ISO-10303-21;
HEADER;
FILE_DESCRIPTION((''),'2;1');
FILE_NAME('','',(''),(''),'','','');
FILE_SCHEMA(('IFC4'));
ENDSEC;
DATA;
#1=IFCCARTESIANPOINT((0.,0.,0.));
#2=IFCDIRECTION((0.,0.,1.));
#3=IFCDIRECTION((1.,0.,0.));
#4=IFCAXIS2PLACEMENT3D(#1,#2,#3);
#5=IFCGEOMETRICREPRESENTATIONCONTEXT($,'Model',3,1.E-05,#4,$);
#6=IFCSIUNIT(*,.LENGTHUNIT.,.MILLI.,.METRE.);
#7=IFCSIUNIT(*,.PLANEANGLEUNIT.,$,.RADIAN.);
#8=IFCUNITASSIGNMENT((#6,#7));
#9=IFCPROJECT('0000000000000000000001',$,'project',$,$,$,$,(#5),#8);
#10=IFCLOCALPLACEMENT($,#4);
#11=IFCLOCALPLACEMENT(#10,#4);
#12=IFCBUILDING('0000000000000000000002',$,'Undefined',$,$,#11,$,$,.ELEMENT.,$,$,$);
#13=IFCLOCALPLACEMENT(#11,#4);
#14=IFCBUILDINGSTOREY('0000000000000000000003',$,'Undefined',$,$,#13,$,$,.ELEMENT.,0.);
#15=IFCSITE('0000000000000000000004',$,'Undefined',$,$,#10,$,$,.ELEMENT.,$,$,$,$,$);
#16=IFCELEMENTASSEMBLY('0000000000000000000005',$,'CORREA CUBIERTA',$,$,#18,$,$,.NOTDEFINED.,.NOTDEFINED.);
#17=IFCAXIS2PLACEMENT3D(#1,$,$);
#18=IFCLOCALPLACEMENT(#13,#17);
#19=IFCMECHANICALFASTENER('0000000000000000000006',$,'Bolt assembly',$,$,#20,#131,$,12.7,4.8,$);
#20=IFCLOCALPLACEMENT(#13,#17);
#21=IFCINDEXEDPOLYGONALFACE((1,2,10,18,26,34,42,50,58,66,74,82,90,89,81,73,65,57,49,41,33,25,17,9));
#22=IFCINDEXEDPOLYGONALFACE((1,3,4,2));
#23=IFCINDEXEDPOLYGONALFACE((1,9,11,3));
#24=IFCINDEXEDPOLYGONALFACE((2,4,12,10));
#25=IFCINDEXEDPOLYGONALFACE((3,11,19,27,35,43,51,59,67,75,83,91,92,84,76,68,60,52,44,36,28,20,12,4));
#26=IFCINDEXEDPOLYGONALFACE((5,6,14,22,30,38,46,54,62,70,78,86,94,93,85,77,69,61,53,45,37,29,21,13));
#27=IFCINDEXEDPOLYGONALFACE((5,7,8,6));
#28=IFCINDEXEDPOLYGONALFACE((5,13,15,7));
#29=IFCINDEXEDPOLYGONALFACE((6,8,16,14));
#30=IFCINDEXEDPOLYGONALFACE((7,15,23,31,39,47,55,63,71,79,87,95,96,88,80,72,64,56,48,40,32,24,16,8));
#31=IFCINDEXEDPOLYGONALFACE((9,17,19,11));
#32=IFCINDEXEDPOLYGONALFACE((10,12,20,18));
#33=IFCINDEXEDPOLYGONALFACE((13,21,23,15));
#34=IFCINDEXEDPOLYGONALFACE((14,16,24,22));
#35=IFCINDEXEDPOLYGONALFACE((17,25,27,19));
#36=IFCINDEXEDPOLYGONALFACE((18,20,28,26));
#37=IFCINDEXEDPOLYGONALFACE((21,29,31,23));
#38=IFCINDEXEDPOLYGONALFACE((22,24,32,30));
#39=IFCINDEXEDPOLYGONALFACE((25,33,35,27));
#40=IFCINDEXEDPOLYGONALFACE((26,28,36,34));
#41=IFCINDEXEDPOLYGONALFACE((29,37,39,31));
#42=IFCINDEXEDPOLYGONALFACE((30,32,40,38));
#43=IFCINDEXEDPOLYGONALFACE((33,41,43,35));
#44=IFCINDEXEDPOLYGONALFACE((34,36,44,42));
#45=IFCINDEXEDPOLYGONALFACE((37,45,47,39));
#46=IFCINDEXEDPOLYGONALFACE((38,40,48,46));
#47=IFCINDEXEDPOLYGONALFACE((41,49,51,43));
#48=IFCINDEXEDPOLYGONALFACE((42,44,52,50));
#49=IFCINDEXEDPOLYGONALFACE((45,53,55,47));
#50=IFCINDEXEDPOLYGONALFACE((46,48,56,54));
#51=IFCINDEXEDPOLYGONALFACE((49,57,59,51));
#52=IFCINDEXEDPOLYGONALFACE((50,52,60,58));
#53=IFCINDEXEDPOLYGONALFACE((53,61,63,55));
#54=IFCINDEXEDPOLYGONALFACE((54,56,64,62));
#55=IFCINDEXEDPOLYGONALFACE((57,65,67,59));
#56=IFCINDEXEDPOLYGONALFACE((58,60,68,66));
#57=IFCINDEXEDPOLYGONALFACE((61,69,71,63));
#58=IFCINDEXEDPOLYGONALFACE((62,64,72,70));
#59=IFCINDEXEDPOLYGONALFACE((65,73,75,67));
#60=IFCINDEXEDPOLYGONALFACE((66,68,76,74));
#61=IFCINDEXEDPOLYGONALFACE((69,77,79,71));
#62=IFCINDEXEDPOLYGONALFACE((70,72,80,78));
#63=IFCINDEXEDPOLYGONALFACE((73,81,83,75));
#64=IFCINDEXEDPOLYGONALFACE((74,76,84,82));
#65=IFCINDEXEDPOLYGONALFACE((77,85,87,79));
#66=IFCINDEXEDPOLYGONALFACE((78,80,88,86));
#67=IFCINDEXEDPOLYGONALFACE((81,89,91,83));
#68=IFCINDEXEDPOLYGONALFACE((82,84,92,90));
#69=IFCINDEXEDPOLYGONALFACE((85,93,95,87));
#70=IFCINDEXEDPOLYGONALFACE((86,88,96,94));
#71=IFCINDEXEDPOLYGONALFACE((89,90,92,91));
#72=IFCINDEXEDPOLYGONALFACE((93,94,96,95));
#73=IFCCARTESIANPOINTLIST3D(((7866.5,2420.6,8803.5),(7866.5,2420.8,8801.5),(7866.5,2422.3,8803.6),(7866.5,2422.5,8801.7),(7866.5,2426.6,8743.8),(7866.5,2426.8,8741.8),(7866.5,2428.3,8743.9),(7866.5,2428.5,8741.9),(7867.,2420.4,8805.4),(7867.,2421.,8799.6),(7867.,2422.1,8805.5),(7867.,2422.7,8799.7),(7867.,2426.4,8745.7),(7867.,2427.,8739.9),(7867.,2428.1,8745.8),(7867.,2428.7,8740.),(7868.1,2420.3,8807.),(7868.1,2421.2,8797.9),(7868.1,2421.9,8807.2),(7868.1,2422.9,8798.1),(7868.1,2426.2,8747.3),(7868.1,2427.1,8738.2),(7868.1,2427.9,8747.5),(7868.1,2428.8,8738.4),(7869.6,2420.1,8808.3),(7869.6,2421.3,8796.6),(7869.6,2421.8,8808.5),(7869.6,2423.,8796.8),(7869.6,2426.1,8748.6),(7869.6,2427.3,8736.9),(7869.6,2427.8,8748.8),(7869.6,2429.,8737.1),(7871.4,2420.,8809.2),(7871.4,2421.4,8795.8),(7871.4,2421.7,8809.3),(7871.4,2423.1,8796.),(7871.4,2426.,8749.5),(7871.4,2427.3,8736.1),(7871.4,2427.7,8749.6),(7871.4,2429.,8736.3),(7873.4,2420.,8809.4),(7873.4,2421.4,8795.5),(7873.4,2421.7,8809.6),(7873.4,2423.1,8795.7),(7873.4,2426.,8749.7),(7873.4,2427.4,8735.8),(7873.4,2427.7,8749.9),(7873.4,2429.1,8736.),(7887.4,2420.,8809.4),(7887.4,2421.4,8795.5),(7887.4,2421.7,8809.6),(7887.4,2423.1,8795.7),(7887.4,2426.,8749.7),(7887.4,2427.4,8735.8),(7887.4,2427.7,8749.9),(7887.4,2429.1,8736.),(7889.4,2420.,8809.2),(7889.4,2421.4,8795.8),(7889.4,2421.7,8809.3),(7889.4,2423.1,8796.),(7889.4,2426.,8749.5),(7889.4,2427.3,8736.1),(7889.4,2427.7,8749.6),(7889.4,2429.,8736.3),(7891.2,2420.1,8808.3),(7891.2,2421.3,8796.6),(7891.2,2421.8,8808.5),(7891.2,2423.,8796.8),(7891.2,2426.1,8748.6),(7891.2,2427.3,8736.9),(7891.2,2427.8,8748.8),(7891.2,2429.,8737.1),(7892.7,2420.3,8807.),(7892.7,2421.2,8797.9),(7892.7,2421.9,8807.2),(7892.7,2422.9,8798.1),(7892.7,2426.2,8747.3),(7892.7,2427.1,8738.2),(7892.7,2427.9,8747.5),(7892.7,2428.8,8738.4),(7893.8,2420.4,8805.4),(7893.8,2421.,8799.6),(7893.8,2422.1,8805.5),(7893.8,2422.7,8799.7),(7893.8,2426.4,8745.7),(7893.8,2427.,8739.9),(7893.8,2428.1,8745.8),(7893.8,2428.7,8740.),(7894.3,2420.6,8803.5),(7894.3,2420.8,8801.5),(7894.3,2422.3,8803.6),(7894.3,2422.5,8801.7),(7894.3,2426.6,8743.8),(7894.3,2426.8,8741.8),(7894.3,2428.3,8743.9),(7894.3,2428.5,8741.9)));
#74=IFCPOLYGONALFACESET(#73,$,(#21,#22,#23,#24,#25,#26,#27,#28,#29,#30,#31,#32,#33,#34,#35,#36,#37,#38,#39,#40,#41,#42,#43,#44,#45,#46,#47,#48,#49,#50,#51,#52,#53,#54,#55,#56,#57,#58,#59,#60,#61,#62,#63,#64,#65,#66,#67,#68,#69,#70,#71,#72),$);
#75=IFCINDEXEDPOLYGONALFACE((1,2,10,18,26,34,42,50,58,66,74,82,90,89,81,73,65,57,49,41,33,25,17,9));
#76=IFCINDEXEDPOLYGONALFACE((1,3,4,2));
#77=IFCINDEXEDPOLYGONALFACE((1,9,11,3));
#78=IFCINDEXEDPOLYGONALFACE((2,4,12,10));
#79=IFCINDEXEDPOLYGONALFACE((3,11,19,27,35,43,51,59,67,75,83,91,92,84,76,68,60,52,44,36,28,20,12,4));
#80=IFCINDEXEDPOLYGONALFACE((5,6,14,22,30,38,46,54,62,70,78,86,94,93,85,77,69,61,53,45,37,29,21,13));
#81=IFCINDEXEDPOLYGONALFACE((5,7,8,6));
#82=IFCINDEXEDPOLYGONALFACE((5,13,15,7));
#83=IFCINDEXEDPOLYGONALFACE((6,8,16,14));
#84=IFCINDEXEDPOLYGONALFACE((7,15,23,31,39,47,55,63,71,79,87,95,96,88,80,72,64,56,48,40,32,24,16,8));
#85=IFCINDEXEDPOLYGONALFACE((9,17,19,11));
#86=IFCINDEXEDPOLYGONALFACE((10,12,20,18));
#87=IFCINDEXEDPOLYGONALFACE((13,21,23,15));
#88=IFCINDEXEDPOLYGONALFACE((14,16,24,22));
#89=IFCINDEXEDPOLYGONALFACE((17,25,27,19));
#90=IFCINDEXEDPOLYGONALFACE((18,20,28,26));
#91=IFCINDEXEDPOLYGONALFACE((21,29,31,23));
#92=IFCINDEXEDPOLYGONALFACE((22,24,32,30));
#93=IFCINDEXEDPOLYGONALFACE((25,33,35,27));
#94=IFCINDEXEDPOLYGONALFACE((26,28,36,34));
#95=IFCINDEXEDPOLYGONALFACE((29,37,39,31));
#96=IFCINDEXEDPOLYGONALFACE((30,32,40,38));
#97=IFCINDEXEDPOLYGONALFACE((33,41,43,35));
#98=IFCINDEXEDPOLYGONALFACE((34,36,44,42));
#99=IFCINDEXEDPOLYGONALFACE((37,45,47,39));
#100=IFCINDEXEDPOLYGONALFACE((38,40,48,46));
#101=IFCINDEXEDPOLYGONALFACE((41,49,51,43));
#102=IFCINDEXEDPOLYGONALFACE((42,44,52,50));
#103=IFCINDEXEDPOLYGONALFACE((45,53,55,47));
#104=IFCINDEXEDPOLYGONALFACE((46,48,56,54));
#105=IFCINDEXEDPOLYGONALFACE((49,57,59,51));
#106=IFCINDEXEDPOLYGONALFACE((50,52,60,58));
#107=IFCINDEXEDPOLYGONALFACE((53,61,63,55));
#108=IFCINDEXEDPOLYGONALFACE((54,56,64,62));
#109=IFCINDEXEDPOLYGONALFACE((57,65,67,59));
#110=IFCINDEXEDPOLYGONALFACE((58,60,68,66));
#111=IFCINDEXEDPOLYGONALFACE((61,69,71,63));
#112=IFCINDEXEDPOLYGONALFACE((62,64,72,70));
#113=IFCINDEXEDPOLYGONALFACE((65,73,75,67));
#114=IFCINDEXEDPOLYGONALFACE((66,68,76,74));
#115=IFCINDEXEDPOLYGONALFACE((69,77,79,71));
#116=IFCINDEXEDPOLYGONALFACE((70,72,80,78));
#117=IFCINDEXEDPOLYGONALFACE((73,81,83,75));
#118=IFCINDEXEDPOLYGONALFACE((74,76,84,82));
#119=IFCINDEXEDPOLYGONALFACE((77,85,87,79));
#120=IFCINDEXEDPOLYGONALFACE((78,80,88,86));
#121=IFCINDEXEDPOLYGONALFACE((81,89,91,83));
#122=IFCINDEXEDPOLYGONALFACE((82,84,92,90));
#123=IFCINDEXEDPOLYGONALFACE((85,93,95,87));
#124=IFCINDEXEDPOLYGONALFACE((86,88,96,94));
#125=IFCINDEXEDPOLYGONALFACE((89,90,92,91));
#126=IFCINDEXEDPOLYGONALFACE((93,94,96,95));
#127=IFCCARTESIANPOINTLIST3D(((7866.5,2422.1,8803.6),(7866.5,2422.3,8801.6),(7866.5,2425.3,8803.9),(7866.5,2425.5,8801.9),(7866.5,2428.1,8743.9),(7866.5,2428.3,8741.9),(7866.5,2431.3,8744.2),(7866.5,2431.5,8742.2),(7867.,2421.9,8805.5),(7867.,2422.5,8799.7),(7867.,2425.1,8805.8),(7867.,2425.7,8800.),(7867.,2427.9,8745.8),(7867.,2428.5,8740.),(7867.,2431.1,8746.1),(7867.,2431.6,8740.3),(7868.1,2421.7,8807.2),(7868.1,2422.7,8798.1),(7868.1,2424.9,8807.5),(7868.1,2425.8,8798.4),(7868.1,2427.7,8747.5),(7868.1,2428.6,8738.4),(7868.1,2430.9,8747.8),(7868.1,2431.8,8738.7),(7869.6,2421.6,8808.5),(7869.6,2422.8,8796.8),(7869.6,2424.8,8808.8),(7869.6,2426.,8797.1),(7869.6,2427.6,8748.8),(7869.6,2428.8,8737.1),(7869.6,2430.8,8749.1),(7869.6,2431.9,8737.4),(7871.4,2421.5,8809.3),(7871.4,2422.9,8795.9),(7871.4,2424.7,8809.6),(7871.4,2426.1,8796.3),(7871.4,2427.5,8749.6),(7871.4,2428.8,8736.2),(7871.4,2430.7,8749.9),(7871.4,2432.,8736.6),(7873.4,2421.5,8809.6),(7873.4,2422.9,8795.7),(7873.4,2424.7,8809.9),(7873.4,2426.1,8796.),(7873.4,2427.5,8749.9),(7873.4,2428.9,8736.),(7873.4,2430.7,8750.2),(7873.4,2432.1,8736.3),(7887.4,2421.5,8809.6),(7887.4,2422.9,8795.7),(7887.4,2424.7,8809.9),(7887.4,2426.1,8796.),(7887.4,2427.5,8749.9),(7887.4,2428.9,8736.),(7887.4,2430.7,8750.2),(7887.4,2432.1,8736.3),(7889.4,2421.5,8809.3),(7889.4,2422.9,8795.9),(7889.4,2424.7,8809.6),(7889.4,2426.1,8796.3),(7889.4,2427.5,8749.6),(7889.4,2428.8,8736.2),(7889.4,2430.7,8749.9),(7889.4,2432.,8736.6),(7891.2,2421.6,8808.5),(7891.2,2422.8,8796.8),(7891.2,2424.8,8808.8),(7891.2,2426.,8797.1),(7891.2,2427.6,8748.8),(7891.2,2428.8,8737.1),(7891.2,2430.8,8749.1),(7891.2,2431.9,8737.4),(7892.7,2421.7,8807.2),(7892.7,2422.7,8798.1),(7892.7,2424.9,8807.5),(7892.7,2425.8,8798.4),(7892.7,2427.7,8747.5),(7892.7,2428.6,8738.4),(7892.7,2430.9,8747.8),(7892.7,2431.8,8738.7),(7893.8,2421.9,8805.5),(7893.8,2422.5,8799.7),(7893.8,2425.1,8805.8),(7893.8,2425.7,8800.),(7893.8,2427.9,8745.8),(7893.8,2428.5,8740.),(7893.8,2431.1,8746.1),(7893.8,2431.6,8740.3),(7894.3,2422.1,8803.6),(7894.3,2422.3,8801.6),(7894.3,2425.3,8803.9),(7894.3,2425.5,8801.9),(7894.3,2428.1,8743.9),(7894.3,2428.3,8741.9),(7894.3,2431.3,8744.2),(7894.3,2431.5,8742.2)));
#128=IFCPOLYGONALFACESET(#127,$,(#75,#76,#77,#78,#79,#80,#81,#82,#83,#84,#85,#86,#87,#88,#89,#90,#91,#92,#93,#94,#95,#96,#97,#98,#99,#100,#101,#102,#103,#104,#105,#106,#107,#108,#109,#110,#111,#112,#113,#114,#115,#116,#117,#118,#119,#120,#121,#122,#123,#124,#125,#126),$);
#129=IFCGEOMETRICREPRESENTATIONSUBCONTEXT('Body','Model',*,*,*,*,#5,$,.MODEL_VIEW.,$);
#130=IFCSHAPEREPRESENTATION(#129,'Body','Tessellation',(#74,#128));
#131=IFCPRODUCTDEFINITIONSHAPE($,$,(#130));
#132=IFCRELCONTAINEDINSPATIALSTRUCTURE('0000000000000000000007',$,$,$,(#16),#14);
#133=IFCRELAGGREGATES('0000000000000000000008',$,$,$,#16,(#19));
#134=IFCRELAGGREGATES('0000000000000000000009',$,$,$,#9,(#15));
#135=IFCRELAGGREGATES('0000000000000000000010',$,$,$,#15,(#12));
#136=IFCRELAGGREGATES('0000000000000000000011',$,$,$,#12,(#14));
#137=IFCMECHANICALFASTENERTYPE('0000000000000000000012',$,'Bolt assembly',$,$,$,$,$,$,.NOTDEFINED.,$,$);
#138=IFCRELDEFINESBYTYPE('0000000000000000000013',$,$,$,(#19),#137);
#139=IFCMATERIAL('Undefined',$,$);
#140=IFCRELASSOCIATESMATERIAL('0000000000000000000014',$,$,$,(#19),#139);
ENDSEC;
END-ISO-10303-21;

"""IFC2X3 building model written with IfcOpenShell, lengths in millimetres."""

from ifc_helpers import new_model, entity, si_unit, frame, origin_with_axes, place, context, subcontext, project, spatial, source, transform, mapped, material, type_object, element, aggregate, save


model = new_model("IFC2X3")

# Units and contexts
model_context = context("Model", 3, precision=1e-05, world=origin_with_axes())
body_context = subcontext(model_context, "Body", "Model", "MODEL_VIEW")
ifc_project = project(units=[si_unit("LENGTHUNIT", "METRE", prefix="MILLI"), si_unit("PLANEANGLEUNIT", "RADIAN")], contexts=[model_context])

# Site, building, storey
site_placement = place(None, origin_with_axes())
site = spatial("IfcSite", under=ifc_project, at=site_placement, Name="Undefined", CompositionType="ELEMENT")
building_placement = place(site_placement, origin_with_axes())
building = spatial("IfcBuilding", under=site, at=building_placement, Name="Undefined", CompositionType="ELEMENT")
storey_placement = place(building_placement, origin_with_axes())
storey = spatial("IfcBuildingStorey", under=building, at=storey_placement, Name="Undefined", CompositionType="ELEMENT", Elevation=0.0)

# Shared definitions
ifc_material_1 = material(Name="Undefined")
mechanical_fastener_type = type_object("IfcMechanicalFastenerType", Name="Bolt assembly")

# Element assembly, mechanical fastener
shared_circle_1 = entity("IfcCircle", entity("IfcAxis2Placement2D", entity("IfcCartesianPoint", [0.0, -7.0]), entity("IfcDirection", [1.0, 0.0])), 7.0)
shared_circle_2 = entity("IfcCircle", entity("IfcAxis2Placement2D", entity("IfcCartesianPoint", [0.0, 7.0]), entity("IfcDirection", [-1.0, 0.0])), 7.0)
shared_composite_curve = entity("IfcCompositeCurve", [entity("IfcCompositeCurveSegment", "CONTINUOUS", True, entity("IfcPolyline", [entity("IfcCartesianPoint", [7.0, 7.0]), entity("IfcCartesianPoint", [7.0, -7.0])])), entity("IfcCompositeCurveSegment", "CONTINUOUS", True, entity("IfcTrimmedCurve", shared_circle_1, [entity("IfcParameterValue", 0.0)], [entity("IfcParameterValue", 3.141593)], False, "PARAMETER")), entity("IfcCompositeCurveSegment", "CONTINUOUS", True, entity("IfcPolyline", [entity("IfcCartesianPoint", [-7.0, -7.0]), entity("IfcCartesianPoint", [-7.0, 7.0])])), entity("IfcCompositeCurveSegment", "DISCONTINUOUS", True, entity("IfcTrimmedCurve", shared_circle_2, [entity("IfcParameterValue", 0.0)], [entity("IfcParameterValue", 3.141593)], False, "PARAMETER"))], False)
assembly_1_placement = place(storey_placement, origin_with_axes())
assembly_1 = element("IfcElementAssembly", 1, at=assembly_1_placement, inside=storey, Name="CORREA CUBIERTA", AssemblyPlace="NOTDEFINED", PredefinedType="NOTDEFINED")
shared_shape_1 = source(origin_with_axes(), body_context, "Body", "SweptSolid", [
    entity("IfcExtrudedAreaSolid", entity("IfcArbitraryClosedProfileDef", "AREA", None, shared_composite_curve), entity("IfcAxis2Placement3D", entity("IfcCartesianPoint", [0.0, 3.1, 0.0]), entity("IfcDirection", [0.0, 1.0, 0.0]), entity("IfcDirection", [1.0, 0.0, 0.0])), entity("IfcDirection", [0.0, 0.0, 1.0]), 1.7),
    entity("IfcExtrudedAreaSolid", entity("IfcArbitraryClosedProfileDef", "AREA", None, shared_composite_curve), entity("IfcAxis2Placement3D", entity("IfcCartesianPoint", [0.0, 0.1, 0.0]), entity("IfcDirection", [0.0, 1.0, 0.0]), entity("IfcDirection", [1.0, 0.0, 0.0])), entity("IfcDirection", [0.0, 0.0, 1.0]), 3.2),
])
mechanical_fastener_1_placement = place(assembly_1_placement, frame((7880.4, 2425.5, 8803.0), z_axis=(-1.0, 0.0, 0.0), x_axis=(0.0, 0.099503, -0.995037)))
mechanical_fastener_1 = element("IfcMechanicalFastener", 2, at=mechanical_fastener_1_placement, type_object=mechanical_fastener_type, material=ifc_material_1, Name="Bolt assembly", NominalDiameter=12.7, NominalLength=4.8, context=body_context, shape_type="MappedRepresentation", body=[
    mapped(shared_shape_1, transform((0.0, 0.0, 0.0))),
    mapped(shared_shape_1, transform((60.0, 0.0, 0.0))),
])

aggregate(assembly_1, [mechanical_fastener_1])

save(model, "model.ifc")
